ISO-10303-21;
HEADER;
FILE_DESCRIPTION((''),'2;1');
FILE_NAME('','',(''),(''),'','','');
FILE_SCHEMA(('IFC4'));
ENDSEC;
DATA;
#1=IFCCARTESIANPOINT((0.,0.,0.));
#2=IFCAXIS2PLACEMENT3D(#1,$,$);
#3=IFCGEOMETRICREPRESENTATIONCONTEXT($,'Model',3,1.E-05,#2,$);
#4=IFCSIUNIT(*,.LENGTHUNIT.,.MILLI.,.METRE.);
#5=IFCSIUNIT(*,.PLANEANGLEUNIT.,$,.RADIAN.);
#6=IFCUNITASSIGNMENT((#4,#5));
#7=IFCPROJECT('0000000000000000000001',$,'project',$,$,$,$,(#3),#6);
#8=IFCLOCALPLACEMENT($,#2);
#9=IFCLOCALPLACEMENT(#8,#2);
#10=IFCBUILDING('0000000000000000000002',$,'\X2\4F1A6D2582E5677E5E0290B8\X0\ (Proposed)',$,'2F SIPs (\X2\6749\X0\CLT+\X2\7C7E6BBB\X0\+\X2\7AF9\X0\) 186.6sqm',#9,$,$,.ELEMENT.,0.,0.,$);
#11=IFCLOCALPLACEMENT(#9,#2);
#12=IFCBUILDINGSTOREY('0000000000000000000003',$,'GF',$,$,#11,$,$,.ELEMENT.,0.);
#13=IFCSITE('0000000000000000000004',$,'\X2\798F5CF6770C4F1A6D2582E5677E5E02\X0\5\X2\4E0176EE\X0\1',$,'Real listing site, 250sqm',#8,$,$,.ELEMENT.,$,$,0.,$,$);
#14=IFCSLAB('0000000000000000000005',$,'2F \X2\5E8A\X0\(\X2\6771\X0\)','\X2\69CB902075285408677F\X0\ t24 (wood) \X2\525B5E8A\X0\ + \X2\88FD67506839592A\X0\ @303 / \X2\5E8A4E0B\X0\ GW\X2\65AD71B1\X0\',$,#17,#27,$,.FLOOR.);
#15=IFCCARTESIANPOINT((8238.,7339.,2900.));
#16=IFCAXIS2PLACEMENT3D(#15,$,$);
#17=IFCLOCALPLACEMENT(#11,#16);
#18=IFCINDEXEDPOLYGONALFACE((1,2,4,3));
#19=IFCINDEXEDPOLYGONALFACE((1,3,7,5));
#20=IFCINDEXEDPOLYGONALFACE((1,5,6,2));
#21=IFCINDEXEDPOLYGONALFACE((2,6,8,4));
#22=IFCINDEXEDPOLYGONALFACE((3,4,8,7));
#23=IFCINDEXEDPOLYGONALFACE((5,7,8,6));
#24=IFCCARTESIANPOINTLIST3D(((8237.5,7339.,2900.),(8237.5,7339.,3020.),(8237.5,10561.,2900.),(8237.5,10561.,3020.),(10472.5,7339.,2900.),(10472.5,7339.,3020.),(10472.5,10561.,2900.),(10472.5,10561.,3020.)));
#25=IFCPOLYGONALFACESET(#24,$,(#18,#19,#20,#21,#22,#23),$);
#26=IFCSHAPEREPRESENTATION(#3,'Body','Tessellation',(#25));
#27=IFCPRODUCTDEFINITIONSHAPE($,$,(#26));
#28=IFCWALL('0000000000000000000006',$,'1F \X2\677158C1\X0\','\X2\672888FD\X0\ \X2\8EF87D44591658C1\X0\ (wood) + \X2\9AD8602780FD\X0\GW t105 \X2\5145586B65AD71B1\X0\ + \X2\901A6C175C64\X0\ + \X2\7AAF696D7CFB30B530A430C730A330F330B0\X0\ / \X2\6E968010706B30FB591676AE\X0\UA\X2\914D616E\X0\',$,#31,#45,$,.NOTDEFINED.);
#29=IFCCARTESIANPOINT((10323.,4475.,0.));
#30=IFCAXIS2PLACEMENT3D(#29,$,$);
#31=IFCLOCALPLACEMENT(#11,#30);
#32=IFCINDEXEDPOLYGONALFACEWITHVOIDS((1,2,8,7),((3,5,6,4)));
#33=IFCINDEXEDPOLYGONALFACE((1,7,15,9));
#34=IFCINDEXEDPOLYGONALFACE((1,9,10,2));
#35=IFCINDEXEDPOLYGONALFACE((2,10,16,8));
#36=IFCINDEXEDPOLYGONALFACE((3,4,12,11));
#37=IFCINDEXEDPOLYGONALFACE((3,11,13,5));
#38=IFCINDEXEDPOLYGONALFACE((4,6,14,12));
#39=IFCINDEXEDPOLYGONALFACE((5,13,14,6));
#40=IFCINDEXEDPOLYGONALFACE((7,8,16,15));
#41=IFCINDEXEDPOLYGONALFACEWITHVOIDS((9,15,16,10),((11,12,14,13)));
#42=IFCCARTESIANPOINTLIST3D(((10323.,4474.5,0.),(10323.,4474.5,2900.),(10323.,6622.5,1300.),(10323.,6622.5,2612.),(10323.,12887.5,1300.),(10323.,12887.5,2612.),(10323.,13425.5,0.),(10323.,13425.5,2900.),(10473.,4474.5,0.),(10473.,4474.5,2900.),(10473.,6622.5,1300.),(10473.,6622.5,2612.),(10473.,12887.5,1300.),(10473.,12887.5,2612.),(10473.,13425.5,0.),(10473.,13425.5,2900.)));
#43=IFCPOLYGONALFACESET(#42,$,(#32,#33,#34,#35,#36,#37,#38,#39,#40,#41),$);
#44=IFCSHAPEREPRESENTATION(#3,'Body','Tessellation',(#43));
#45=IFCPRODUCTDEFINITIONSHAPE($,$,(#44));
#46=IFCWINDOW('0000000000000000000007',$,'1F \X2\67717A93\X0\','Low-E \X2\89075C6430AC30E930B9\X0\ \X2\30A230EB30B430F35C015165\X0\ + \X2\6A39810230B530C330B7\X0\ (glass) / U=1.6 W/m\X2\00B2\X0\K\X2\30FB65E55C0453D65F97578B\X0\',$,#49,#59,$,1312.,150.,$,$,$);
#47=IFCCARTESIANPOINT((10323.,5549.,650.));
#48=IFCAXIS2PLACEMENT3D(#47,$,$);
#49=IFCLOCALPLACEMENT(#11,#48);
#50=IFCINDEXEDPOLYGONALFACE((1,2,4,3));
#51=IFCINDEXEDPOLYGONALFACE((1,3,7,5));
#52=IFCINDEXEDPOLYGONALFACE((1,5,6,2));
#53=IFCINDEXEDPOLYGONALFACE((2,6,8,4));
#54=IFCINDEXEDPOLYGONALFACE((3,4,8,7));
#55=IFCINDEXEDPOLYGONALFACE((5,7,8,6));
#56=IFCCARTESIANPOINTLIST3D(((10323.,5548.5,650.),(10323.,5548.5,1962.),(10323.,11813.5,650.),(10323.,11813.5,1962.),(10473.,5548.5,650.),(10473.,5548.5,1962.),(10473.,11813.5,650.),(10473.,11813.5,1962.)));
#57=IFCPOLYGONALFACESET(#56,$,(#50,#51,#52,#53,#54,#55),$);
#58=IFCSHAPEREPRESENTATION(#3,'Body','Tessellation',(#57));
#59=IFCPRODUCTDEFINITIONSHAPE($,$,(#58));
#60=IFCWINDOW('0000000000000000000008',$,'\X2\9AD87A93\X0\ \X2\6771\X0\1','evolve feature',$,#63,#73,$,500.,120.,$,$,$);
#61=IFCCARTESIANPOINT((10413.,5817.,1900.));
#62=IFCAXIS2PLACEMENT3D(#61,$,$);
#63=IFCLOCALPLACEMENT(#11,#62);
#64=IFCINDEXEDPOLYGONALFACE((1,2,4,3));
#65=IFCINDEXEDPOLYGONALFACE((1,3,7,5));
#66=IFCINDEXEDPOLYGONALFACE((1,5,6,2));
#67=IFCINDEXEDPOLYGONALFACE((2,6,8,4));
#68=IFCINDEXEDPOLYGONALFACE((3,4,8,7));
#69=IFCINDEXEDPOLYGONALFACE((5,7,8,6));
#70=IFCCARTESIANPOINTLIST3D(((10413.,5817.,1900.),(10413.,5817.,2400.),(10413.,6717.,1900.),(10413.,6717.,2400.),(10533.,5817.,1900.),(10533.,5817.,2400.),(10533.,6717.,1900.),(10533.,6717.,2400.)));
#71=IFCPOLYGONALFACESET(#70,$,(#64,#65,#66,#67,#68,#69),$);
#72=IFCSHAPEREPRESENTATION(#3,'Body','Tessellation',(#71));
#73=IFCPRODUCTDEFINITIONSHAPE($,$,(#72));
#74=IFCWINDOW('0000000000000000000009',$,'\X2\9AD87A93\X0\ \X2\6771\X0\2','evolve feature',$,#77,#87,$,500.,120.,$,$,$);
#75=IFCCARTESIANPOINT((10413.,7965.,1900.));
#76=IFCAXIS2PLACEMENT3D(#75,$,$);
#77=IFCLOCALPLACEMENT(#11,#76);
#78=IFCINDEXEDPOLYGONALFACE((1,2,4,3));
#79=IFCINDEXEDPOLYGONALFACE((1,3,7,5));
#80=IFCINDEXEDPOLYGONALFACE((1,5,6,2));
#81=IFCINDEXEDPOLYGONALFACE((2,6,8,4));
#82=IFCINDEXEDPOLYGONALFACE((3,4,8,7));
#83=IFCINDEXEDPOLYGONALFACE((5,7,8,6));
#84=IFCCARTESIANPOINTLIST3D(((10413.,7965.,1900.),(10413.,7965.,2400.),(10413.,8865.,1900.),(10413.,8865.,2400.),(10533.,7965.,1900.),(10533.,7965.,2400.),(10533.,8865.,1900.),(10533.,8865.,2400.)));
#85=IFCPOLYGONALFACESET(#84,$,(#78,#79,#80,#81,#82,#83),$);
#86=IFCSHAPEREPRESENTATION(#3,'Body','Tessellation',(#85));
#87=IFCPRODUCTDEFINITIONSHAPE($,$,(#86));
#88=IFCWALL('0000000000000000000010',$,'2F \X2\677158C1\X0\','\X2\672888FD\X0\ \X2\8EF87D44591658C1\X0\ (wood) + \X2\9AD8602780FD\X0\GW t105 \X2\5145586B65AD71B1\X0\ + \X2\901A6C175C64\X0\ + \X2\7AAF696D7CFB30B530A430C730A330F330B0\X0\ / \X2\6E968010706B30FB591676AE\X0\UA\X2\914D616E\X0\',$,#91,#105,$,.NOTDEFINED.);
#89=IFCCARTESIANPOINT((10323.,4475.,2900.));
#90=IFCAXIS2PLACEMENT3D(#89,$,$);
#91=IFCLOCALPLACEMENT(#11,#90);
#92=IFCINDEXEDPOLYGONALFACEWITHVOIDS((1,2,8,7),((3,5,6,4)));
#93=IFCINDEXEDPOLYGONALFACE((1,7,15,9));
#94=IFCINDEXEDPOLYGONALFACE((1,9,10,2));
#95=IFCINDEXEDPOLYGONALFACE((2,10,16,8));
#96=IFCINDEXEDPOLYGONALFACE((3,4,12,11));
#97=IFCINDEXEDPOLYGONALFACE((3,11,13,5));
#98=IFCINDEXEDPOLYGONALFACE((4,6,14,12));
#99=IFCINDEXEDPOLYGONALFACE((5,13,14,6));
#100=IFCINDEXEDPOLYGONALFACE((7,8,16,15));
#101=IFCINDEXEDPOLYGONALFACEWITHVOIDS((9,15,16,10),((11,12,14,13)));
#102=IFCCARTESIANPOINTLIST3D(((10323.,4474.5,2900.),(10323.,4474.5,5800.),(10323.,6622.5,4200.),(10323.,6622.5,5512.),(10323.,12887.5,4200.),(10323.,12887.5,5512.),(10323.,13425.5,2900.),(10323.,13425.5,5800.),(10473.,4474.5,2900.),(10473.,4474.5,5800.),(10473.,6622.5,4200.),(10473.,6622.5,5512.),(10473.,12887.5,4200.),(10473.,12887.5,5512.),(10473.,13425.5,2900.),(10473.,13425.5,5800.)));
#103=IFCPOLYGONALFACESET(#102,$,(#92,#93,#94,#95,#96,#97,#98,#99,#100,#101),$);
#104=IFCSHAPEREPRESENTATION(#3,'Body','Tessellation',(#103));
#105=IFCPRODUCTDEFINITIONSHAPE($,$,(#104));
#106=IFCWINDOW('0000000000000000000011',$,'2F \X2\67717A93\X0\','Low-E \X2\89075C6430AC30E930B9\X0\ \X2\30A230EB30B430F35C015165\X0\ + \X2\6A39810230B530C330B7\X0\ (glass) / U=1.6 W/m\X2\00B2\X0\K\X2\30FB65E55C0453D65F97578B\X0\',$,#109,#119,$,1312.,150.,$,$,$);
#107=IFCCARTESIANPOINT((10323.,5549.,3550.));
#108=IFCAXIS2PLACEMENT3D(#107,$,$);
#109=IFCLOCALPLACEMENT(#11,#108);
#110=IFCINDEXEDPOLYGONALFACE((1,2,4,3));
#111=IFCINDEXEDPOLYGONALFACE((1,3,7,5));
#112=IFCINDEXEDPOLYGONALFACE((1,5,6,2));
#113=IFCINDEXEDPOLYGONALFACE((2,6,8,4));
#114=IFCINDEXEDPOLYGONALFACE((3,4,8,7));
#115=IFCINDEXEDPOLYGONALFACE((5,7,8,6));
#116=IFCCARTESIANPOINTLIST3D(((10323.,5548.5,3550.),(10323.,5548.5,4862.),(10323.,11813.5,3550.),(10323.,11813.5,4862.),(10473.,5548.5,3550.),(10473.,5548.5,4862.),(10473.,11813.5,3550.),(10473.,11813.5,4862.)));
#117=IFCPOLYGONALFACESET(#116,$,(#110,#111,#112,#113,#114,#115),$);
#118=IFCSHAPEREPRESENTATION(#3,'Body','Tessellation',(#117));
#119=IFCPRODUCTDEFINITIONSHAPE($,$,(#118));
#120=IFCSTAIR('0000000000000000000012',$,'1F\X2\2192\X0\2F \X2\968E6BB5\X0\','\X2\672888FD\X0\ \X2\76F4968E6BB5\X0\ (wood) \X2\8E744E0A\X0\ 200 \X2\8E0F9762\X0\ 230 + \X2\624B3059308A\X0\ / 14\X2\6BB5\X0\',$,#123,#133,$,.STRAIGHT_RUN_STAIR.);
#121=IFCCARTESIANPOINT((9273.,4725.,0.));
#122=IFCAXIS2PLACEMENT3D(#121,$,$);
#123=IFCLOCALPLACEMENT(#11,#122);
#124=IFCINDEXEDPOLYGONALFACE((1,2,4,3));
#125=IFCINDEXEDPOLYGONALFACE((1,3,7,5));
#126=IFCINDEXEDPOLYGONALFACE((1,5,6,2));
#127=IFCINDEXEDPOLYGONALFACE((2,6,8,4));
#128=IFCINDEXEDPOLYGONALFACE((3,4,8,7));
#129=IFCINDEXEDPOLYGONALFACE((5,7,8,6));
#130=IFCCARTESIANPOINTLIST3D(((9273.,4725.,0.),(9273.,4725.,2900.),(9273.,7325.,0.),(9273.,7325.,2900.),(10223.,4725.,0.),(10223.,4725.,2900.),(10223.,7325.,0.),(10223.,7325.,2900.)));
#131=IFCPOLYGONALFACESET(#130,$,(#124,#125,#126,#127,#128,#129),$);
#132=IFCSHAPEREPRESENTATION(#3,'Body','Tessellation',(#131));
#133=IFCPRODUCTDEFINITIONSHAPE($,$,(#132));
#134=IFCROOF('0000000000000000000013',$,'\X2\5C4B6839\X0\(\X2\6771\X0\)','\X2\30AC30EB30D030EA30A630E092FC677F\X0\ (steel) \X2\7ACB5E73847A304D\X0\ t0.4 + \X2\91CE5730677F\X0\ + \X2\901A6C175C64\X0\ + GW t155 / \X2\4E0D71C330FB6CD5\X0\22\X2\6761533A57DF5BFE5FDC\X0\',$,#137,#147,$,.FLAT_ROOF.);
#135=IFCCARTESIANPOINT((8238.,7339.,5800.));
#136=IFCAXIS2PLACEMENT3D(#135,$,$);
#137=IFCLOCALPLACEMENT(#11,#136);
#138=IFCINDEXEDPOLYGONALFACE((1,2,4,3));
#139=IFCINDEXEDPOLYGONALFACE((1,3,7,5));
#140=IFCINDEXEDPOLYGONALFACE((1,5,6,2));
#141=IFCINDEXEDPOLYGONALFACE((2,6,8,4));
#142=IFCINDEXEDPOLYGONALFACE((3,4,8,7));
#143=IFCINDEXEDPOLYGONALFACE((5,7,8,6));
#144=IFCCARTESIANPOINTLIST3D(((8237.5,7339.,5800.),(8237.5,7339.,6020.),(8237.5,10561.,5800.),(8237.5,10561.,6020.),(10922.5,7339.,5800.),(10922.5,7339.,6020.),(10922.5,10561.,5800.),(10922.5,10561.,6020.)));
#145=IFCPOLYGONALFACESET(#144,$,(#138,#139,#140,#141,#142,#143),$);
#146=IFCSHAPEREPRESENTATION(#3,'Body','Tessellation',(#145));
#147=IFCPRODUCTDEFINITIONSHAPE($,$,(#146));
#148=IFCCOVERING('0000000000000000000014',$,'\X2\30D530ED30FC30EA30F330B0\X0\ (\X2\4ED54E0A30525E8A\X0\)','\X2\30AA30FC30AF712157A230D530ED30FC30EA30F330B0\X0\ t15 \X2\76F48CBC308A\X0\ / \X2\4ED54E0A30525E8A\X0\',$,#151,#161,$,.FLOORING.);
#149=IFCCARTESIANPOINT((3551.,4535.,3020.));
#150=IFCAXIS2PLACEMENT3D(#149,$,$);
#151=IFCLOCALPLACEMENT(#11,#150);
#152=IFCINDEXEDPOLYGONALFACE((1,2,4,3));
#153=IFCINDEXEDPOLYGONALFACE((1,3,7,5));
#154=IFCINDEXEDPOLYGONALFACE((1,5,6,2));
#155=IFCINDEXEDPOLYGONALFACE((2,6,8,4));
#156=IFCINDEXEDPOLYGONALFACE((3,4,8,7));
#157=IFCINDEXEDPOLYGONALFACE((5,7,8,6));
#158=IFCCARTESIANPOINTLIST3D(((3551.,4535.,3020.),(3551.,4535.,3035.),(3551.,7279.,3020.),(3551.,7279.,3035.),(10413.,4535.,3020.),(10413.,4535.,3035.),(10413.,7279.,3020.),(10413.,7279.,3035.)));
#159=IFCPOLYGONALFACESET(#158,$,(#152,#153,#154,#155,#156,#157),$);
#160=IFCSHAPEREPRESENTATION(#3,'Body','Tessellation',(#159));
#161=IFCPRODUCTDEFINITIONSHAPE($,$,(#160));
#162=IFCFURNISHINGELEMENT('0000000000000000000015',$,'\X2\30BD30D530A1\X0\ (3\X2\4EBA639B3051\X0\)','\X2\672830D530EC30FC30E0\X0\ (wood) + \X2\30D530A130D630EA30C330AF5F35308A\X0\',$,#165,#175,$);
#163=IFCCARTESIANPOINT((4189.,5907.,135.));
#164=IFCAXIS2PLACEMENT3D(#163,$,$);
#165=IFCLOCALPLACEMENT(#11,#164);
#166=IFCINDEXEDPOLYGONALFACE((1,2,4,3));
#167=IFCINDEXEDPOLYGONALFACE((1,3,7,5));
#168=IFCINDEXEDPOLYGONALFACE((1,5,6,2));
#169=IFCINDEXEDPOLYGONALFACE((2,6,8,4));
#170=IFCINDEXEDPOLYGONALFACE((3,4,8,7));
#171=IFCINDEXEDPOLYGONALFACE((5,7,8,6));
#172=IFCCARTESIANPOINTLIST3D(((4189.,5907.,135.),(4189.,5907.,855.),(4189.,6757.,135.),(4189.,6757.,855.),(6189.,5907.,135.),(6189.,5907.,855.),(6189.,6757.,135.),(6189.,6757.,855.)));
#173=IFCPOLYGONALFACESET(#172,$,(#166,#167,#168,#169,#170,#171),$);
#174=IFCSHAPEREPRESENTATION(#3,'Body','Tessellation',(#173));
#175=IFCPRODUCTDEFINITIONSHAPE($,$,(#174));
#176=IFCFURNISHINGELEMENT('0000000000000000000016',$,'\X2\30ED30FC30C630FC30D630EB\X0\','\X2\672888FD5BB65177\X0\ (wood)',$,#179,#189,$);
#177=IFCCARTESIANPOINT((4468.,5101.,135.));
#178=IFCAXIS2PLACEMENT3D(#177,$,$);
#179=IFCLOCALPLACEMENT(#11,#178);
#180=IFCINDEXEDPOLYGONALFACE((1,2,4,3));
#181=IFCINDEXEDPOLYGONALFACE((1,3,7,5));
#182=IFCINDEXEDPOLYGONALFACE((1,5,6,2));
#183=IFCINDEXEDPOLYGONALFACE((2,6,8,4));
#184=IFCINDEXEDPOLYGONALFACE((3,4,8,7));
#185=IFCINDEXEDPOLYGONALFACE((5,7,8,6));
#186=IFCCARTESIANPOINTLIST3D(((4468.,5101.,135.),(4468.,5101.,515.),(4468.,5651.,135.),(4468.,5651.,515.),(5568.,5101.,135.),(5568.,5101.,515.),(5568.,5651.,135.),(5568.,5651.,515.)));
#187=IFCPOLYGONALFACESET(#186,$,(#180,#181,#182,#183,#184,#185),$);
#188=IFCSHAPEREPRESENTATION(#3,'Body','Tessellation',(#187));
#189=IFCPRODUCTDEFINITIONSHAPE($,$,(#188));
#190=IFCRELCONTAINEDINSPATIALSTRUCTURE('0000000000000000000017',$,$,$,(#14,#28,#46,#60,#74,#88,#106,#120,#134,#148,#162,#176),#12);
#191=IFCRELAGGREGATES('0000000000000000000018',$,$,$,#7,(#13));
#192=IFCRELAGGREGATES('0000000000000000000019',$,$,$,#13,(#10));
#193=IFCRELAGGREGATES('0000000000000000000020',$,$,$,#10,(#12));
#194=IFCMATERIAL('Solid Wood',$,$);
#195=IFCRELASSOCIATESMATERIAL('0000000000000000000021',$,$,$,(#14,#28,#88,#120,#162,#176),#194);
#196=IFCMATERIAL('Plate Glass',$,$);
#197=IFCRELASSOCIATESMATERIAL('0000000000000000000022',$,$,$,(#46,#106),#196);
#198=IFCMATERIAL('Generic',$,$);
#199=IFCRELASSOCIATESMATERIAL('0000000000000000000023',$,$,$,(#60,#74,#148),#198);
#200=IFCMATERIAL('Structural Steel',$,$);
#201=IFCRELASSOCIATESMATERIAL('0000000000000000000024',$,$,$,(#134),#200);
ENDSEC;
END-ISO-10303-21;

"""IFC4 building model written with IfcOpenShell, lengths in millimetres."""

from ifc_helpers import new_model, si_unit, frame, frame_2d, origin, place, context, project, spatial, rectangle, extrude, material, element, fill, save


model = new_model("IFC4")

# Units and contexts
model_context = context("Model", 3, precision=1e-05, world=origin())
ifc_project = project(units=[si_unit("LENGTHUNIT", "METRE", prefix="MILLI"), si_unit("PLANEANGLEUNIT", "RADIAN")], contexts=[model_context])

# Site, building, storey
site_placement = place(None, origin())
site = spatial("IfcSite", under=ifc_project, at=site_placement, Name="福島県会津若松市5丁目1", ObjectType="Real listing site, 250sqm", CompositionType="ELEMENT", RefElevation=0.0)
building_placement = place(site_placement, origin())
building = spatial("IfcBuilding", under=site, at=building_placement, Name="会津若松市邸 (Proposed)", ObjectType="2F SIPs (杉CLT+籾殻+竹) 186.6sqm", CompositionType="ELEMENT", ElevationOfRefHeight=0.0, ElevationOfTerrain=0.0)
storey_placement = place(building_placement, origin())
storey = spatial("IfcBuildingStorey", under=building, at=storey_placement, Name="GF", CompositionType="ELEMENT", Elevation=0.0)

# Slab
ifc_material_1 = material(Name="Solid Wood")
slab_1_placement = place(storey_placement, frame((8238.0, 7339.0, 2900.0)))
element("IfcSlab", 1, at=slab_1_placement, inside=storey, material=ifc_material_1, Name="2F 床(東)", Description="構造用合板 t24 (wood) 剛床 + 製材根太 @303 / 床下 GW断熱", PredefinedType="FLOOR", context=model_context, shape_type="SweptSolid", body=[
    extrude(rectangle(XDim=2235.0, YDim=3222.0, at=frame_2d((1117.0, 1611.0))), frame((8238.0, 7339.0, 2900.0)), (0.0, 0.0, 1.0), 120.0),
])

# Wall, openings, windows
wall_1_placement = place(storey_placement, frame((10323.0, 4475.0, 0.0)))
wall_1 = element("IfcWall", 2, at=wall_1_placement, inside=storey, material=ifc_material_1, Name="1F 東壁", Description="木製 軸組外壁 (wood) + 高性能GW t105 充填断熱 + 通気層 + 窯業系サイディング / 準耐火・外皮UA配慮", PredefinedType="NOTDEFINED", context=model_context, shape_type="SweptSolid", body=[
    extrude(rectangle(XDim=150.0, YDim=8951.0, at=frame_2d((75.0, 4475.0))), frame((10323.0, 4475.0, 0.0)), (0.0, 0.0, 1.0), 2900.0),
])
opening_1_placement = place(storey_placement, frame((10323.0, 5549.0, 650.0)))
opening_1 = element("IfcOpeningElement", 3, at=opening_1_placement, cuts=wall_1, PredefinedType="NOTDEFINED", context=model_context, shape_type="SweptSolid", body=[
    extrude(rectangle(XDim=150.0, YDim=6265.0, at=frame_2d((75.0, 3132.0))), frame((10323.0, 5549.0, 650.0)), (0.0, 0.0, 1.0), 1312.0),
])
opening_2_placement = place(storey_placement, frame((10413.0, 5817.0, 1900.0)))
opening_2 = element("IfcOpeningElement", 4, at=opening_2_placement, cuts=wall_1, PredefinedType="NOTDEFINED", context=model_context, shape_type="SweptSolid", body=[
    extrude(rectangle(XDim=120.0, YDim=900.0, at=frame_2d((60.0, 450.0))), frame((10413.0, 5817.0, 1900.0)), (0.0, 0.0, 1.0), 500.0),
])
opening_3_placement = place(storey_placement, frame((10413.0, 7965.0, 1900.0)))
opening_3 = element("IfcOpeningElement", 5, at=opening_3_placement, cuts=wall_1, PredefinedType="NOTDEFINED", context=model_context, shape_type="SweptSolid", body=[
    extrude(rectangle(XDim=120.0, YDim=900.0, at=frame_2d((60.0, 450.0))), frame((10413.0, 7965.0, 1900.0)), (0.0, 0.0, 1.0), 500.0),
])
ifc_material_2 = material(Name="Plate Glass")
window_1_placement = place(storey_placement, frame((10323.0, 5549.0, 650.0)))
window_1 = element("IfcWindow", 6, at=window_1_placement, inside=storey, material=ifc_material_2, Name="1F 東窓", Description="Low-E 複層ガラス アルゴン封入 + 樹脂サッシ (glass) / U=1.6 W/m²K・日射取得型", OverallHeight=1312.0, OverallWidth=150.0, context=model_context, shape_type="SweptSolid", body=[
    extrude(rectangle(XDim=150.0, YDim=6265.0, at=frame_2d((75.0, 3132.0))), frame((10323.0, 5549.0, 650.0)), (0.0, 0.0, 1.0), 1312.0),
])
fill(opening_1, window_1)
ifc_material_3 = material(Name="Generic")
window_2_placement = place(storey_placement, frame((10413.0, 5817.0, 1900.0)))
window_2 = element("IfcWindow", 7, at=window_2_placement, inside=storey, material=ifc_material_3, Name="高窓 東1", Description="evolve feature", OverallHeight=500.0, OverallWidth=120.0, context=model_context, shape_type="SweptSolid", body=[
    extrude(rectangle(XDim=120.0, YDim=900.0, at=frame_2d((60.0, 450.0))), frame((10413.0, 5817.0, 1900.0)), (0.0, 0.0, 1.0), 500.0),
])
fill(opening_2, window_2)
window_3_placement = place(storey_placement, frame((10413.0, 7965.0, 1900.0)))
window_3 = element("IfcWindow", 8, at=window_3_placement, inside=storey, material=ifc_material_3, Name="高窓 東2", Description="evolve feature", OverallHeight=500.0, OverallWidth=120.0, context=model_context, shape_type="SweptSolid", body=[
    extrude(rectangle(XDim=120.0, YDim=900.0, at=frame_2d((60.0, 450.0))), frame((10413.0, 7965.0, 1900.0)), (0.0, 0.0, 1.0), 500.0),
])
fill(opening_3, window_3)

# Wall, opening, window
wall_2_placement = place(storey_placement, frame((10323.0, 4475.0, 2900.0)))
wall_2 = element("IfcWall", 9, at=wall_2_placement, inside=storey, material=ifc_material_1, Name="2F 東壁", Description="木製 軸組外壁 (wood) + 高性能GW t105 充填断熱 + 通気層 + 窯業系サイディング / 準耐火・外皮UA配慮", PredefinedType="NOTDEFINED", context=model_context, shape_type="SweptSolid", body=[
    extrude(rectangle(XDim=150.0, YDim=8951.0, at=frame_2d((75.0, 4475.0))), frame((10323.0, 4475.0, 2900.0)), (0.0, 0.0, 1.0), 2900.0),
])
opening_4_placement = place(storey_placement, frame((10323.0, 5549.0, 3550.0)))
opening_4 = element("IfcOpeningElement", 10, at=opening_4_placement, cuts=wall_2, PredefinedType="NOTDEFINED", context=model_context, shape_type="SweptSolid", body=[
    extrude(rectangle(XDim=150.0, YDim=6265.0, at=frame_2d((75.0, 3132.0))), frame((10323.0, 5549.0, 3550.0)), (0.0, 0.0, 1.0), 1312.0),
])
window_4_placement = place(storey_placement, frame((10323.0, 5549.0, 3550.0)))
window_4 = element("IfcWindow", 11, at=window_4_placement, inside=storey, material=ifc_material_2, Name="2F 東窓", Description="Low-E 複層ガラス アルゴン封入 + 樹脂サッシ (glass) / U=1.6 W/m²K・日射取得型", OverallHeight=1312.0, OverallWidth=150.0, context=model_context, shape_type="SweptSolid", body=[
    extrude(rectangle(XDim=150.0, YDim=6265.0, at=frame_2d((75.0, 3132.0))), frame((10323.0, 5549.0, 3550.0)), (0.0, 0.0, 1.0), 1312.0),
])
fill(opening_4, window_4)

# Stair
stair_placement = place(storey_placement, frame((9273.0, 4725.0, 0.0)))
element("IfcStair", 12, at=stair_placement, inside=storey, material=ifc_material_1, Name="1F→2F 階段", Description="木製 直階段 (wood) 蹴上 200 踏面 230 + 手すり / 14段", PredefinedType="STRAIGHT_RUN_STAIR", context=model_context, shape_type="SweptSolid", body=[
    extrude(rectangle(XDim=950.0, YDim=2600.0, at=frame_2d((475.0, 1300.0))), frame((9273.0, 4725.0, 0.0)), (0.0, 0.0, 1.0), 2900.0),
])

# Roof
ifc_material_4 = material(Name="Structural Steel")
roof_placement = place(storey_placement, frame((8238.0, 7339.0, 5800.0)))
element("IfcRoof", 13, at=roof_placement, inside=storey, material=ifc_material_4, Name="屋根(東)", Description="ガルバリウム鋼板 (steel) 立平葺き t0.4 + 野地板 + 通気層 + GW t155 / 不燃・法22条区域対応", PredefinedType="FLAT_ROOF", context=model_context, shape_type="SweptSolid", body=[
    extrude(rectangle(XDim=2685.0, YDim=3222.0, at=frame_2d((1342.0, 1611.0))), frame((8238.0, 7339.0, 5800.0)), (0.0, 0.0, 1.0), 220.0),
])

# Covering
covering_placement = place(storey_placement, frame((3551.0, 4535.0, 3020.0)))
element("IfcCovering", 14, at=covering_placement, inside=storey, material=ifc_material_3, Name="フローリング (仕上げ床)", Description="オーク無垢フローリング t15 直貼り / 仕上げ床", PredefinedType="FLOORING", context=model_context, shape_type="SweptSolid", body=[
    extrude(rectangle(XDim=6862.0, YDim=2744.0, at=frame_2d((3431.0, 1372.0))), frame((3551.0, 4535.0, 3020.0)), (0.0, 0.0, 1.0), 15.0),
])

# Furnishing elements
furnishing_1_placement = place(storey_placement, frame((4189.0, 5907.0, 135.0)))
element("IfcFurnishingElement", 15, at=furnishing_1_placement, inside=storey, material=ifc_material_1, Name="ソファ (3人掛け)", Description="木フレーム (wood) + ファブリック張り", context=model_context, shape_type="SweptSolid", body=[
    extrude(rectangle(XDim=2000.0, YDim=850.0, at=frame_2d((1000.0, 425.0))), frame((4189.0, 5907.0, 135.0)), (0.0, 0.0, 1.0), 720.0),
])
furnishing_2_placement = place(storey_placement, frame((4468.0, 5101.0, 135.0)))
element("IfcFurnishingElement", 16, at=furnishing_2_placement, inside=storey, material=ifc_material_1, Name="ローテーブル", Description="木製家具 (wood)", context=model_context, shape_type="SweptSolid", body=[
    extrude(rectangle(XDim=1100.0, YDim=550.0, at=frame_2d((550.0, 275.0))), frame((4468.0, 5101.0, 135.0)), (0.0, 0.0, 1.0), 380.0),
])

save(model, "model.ifc")
